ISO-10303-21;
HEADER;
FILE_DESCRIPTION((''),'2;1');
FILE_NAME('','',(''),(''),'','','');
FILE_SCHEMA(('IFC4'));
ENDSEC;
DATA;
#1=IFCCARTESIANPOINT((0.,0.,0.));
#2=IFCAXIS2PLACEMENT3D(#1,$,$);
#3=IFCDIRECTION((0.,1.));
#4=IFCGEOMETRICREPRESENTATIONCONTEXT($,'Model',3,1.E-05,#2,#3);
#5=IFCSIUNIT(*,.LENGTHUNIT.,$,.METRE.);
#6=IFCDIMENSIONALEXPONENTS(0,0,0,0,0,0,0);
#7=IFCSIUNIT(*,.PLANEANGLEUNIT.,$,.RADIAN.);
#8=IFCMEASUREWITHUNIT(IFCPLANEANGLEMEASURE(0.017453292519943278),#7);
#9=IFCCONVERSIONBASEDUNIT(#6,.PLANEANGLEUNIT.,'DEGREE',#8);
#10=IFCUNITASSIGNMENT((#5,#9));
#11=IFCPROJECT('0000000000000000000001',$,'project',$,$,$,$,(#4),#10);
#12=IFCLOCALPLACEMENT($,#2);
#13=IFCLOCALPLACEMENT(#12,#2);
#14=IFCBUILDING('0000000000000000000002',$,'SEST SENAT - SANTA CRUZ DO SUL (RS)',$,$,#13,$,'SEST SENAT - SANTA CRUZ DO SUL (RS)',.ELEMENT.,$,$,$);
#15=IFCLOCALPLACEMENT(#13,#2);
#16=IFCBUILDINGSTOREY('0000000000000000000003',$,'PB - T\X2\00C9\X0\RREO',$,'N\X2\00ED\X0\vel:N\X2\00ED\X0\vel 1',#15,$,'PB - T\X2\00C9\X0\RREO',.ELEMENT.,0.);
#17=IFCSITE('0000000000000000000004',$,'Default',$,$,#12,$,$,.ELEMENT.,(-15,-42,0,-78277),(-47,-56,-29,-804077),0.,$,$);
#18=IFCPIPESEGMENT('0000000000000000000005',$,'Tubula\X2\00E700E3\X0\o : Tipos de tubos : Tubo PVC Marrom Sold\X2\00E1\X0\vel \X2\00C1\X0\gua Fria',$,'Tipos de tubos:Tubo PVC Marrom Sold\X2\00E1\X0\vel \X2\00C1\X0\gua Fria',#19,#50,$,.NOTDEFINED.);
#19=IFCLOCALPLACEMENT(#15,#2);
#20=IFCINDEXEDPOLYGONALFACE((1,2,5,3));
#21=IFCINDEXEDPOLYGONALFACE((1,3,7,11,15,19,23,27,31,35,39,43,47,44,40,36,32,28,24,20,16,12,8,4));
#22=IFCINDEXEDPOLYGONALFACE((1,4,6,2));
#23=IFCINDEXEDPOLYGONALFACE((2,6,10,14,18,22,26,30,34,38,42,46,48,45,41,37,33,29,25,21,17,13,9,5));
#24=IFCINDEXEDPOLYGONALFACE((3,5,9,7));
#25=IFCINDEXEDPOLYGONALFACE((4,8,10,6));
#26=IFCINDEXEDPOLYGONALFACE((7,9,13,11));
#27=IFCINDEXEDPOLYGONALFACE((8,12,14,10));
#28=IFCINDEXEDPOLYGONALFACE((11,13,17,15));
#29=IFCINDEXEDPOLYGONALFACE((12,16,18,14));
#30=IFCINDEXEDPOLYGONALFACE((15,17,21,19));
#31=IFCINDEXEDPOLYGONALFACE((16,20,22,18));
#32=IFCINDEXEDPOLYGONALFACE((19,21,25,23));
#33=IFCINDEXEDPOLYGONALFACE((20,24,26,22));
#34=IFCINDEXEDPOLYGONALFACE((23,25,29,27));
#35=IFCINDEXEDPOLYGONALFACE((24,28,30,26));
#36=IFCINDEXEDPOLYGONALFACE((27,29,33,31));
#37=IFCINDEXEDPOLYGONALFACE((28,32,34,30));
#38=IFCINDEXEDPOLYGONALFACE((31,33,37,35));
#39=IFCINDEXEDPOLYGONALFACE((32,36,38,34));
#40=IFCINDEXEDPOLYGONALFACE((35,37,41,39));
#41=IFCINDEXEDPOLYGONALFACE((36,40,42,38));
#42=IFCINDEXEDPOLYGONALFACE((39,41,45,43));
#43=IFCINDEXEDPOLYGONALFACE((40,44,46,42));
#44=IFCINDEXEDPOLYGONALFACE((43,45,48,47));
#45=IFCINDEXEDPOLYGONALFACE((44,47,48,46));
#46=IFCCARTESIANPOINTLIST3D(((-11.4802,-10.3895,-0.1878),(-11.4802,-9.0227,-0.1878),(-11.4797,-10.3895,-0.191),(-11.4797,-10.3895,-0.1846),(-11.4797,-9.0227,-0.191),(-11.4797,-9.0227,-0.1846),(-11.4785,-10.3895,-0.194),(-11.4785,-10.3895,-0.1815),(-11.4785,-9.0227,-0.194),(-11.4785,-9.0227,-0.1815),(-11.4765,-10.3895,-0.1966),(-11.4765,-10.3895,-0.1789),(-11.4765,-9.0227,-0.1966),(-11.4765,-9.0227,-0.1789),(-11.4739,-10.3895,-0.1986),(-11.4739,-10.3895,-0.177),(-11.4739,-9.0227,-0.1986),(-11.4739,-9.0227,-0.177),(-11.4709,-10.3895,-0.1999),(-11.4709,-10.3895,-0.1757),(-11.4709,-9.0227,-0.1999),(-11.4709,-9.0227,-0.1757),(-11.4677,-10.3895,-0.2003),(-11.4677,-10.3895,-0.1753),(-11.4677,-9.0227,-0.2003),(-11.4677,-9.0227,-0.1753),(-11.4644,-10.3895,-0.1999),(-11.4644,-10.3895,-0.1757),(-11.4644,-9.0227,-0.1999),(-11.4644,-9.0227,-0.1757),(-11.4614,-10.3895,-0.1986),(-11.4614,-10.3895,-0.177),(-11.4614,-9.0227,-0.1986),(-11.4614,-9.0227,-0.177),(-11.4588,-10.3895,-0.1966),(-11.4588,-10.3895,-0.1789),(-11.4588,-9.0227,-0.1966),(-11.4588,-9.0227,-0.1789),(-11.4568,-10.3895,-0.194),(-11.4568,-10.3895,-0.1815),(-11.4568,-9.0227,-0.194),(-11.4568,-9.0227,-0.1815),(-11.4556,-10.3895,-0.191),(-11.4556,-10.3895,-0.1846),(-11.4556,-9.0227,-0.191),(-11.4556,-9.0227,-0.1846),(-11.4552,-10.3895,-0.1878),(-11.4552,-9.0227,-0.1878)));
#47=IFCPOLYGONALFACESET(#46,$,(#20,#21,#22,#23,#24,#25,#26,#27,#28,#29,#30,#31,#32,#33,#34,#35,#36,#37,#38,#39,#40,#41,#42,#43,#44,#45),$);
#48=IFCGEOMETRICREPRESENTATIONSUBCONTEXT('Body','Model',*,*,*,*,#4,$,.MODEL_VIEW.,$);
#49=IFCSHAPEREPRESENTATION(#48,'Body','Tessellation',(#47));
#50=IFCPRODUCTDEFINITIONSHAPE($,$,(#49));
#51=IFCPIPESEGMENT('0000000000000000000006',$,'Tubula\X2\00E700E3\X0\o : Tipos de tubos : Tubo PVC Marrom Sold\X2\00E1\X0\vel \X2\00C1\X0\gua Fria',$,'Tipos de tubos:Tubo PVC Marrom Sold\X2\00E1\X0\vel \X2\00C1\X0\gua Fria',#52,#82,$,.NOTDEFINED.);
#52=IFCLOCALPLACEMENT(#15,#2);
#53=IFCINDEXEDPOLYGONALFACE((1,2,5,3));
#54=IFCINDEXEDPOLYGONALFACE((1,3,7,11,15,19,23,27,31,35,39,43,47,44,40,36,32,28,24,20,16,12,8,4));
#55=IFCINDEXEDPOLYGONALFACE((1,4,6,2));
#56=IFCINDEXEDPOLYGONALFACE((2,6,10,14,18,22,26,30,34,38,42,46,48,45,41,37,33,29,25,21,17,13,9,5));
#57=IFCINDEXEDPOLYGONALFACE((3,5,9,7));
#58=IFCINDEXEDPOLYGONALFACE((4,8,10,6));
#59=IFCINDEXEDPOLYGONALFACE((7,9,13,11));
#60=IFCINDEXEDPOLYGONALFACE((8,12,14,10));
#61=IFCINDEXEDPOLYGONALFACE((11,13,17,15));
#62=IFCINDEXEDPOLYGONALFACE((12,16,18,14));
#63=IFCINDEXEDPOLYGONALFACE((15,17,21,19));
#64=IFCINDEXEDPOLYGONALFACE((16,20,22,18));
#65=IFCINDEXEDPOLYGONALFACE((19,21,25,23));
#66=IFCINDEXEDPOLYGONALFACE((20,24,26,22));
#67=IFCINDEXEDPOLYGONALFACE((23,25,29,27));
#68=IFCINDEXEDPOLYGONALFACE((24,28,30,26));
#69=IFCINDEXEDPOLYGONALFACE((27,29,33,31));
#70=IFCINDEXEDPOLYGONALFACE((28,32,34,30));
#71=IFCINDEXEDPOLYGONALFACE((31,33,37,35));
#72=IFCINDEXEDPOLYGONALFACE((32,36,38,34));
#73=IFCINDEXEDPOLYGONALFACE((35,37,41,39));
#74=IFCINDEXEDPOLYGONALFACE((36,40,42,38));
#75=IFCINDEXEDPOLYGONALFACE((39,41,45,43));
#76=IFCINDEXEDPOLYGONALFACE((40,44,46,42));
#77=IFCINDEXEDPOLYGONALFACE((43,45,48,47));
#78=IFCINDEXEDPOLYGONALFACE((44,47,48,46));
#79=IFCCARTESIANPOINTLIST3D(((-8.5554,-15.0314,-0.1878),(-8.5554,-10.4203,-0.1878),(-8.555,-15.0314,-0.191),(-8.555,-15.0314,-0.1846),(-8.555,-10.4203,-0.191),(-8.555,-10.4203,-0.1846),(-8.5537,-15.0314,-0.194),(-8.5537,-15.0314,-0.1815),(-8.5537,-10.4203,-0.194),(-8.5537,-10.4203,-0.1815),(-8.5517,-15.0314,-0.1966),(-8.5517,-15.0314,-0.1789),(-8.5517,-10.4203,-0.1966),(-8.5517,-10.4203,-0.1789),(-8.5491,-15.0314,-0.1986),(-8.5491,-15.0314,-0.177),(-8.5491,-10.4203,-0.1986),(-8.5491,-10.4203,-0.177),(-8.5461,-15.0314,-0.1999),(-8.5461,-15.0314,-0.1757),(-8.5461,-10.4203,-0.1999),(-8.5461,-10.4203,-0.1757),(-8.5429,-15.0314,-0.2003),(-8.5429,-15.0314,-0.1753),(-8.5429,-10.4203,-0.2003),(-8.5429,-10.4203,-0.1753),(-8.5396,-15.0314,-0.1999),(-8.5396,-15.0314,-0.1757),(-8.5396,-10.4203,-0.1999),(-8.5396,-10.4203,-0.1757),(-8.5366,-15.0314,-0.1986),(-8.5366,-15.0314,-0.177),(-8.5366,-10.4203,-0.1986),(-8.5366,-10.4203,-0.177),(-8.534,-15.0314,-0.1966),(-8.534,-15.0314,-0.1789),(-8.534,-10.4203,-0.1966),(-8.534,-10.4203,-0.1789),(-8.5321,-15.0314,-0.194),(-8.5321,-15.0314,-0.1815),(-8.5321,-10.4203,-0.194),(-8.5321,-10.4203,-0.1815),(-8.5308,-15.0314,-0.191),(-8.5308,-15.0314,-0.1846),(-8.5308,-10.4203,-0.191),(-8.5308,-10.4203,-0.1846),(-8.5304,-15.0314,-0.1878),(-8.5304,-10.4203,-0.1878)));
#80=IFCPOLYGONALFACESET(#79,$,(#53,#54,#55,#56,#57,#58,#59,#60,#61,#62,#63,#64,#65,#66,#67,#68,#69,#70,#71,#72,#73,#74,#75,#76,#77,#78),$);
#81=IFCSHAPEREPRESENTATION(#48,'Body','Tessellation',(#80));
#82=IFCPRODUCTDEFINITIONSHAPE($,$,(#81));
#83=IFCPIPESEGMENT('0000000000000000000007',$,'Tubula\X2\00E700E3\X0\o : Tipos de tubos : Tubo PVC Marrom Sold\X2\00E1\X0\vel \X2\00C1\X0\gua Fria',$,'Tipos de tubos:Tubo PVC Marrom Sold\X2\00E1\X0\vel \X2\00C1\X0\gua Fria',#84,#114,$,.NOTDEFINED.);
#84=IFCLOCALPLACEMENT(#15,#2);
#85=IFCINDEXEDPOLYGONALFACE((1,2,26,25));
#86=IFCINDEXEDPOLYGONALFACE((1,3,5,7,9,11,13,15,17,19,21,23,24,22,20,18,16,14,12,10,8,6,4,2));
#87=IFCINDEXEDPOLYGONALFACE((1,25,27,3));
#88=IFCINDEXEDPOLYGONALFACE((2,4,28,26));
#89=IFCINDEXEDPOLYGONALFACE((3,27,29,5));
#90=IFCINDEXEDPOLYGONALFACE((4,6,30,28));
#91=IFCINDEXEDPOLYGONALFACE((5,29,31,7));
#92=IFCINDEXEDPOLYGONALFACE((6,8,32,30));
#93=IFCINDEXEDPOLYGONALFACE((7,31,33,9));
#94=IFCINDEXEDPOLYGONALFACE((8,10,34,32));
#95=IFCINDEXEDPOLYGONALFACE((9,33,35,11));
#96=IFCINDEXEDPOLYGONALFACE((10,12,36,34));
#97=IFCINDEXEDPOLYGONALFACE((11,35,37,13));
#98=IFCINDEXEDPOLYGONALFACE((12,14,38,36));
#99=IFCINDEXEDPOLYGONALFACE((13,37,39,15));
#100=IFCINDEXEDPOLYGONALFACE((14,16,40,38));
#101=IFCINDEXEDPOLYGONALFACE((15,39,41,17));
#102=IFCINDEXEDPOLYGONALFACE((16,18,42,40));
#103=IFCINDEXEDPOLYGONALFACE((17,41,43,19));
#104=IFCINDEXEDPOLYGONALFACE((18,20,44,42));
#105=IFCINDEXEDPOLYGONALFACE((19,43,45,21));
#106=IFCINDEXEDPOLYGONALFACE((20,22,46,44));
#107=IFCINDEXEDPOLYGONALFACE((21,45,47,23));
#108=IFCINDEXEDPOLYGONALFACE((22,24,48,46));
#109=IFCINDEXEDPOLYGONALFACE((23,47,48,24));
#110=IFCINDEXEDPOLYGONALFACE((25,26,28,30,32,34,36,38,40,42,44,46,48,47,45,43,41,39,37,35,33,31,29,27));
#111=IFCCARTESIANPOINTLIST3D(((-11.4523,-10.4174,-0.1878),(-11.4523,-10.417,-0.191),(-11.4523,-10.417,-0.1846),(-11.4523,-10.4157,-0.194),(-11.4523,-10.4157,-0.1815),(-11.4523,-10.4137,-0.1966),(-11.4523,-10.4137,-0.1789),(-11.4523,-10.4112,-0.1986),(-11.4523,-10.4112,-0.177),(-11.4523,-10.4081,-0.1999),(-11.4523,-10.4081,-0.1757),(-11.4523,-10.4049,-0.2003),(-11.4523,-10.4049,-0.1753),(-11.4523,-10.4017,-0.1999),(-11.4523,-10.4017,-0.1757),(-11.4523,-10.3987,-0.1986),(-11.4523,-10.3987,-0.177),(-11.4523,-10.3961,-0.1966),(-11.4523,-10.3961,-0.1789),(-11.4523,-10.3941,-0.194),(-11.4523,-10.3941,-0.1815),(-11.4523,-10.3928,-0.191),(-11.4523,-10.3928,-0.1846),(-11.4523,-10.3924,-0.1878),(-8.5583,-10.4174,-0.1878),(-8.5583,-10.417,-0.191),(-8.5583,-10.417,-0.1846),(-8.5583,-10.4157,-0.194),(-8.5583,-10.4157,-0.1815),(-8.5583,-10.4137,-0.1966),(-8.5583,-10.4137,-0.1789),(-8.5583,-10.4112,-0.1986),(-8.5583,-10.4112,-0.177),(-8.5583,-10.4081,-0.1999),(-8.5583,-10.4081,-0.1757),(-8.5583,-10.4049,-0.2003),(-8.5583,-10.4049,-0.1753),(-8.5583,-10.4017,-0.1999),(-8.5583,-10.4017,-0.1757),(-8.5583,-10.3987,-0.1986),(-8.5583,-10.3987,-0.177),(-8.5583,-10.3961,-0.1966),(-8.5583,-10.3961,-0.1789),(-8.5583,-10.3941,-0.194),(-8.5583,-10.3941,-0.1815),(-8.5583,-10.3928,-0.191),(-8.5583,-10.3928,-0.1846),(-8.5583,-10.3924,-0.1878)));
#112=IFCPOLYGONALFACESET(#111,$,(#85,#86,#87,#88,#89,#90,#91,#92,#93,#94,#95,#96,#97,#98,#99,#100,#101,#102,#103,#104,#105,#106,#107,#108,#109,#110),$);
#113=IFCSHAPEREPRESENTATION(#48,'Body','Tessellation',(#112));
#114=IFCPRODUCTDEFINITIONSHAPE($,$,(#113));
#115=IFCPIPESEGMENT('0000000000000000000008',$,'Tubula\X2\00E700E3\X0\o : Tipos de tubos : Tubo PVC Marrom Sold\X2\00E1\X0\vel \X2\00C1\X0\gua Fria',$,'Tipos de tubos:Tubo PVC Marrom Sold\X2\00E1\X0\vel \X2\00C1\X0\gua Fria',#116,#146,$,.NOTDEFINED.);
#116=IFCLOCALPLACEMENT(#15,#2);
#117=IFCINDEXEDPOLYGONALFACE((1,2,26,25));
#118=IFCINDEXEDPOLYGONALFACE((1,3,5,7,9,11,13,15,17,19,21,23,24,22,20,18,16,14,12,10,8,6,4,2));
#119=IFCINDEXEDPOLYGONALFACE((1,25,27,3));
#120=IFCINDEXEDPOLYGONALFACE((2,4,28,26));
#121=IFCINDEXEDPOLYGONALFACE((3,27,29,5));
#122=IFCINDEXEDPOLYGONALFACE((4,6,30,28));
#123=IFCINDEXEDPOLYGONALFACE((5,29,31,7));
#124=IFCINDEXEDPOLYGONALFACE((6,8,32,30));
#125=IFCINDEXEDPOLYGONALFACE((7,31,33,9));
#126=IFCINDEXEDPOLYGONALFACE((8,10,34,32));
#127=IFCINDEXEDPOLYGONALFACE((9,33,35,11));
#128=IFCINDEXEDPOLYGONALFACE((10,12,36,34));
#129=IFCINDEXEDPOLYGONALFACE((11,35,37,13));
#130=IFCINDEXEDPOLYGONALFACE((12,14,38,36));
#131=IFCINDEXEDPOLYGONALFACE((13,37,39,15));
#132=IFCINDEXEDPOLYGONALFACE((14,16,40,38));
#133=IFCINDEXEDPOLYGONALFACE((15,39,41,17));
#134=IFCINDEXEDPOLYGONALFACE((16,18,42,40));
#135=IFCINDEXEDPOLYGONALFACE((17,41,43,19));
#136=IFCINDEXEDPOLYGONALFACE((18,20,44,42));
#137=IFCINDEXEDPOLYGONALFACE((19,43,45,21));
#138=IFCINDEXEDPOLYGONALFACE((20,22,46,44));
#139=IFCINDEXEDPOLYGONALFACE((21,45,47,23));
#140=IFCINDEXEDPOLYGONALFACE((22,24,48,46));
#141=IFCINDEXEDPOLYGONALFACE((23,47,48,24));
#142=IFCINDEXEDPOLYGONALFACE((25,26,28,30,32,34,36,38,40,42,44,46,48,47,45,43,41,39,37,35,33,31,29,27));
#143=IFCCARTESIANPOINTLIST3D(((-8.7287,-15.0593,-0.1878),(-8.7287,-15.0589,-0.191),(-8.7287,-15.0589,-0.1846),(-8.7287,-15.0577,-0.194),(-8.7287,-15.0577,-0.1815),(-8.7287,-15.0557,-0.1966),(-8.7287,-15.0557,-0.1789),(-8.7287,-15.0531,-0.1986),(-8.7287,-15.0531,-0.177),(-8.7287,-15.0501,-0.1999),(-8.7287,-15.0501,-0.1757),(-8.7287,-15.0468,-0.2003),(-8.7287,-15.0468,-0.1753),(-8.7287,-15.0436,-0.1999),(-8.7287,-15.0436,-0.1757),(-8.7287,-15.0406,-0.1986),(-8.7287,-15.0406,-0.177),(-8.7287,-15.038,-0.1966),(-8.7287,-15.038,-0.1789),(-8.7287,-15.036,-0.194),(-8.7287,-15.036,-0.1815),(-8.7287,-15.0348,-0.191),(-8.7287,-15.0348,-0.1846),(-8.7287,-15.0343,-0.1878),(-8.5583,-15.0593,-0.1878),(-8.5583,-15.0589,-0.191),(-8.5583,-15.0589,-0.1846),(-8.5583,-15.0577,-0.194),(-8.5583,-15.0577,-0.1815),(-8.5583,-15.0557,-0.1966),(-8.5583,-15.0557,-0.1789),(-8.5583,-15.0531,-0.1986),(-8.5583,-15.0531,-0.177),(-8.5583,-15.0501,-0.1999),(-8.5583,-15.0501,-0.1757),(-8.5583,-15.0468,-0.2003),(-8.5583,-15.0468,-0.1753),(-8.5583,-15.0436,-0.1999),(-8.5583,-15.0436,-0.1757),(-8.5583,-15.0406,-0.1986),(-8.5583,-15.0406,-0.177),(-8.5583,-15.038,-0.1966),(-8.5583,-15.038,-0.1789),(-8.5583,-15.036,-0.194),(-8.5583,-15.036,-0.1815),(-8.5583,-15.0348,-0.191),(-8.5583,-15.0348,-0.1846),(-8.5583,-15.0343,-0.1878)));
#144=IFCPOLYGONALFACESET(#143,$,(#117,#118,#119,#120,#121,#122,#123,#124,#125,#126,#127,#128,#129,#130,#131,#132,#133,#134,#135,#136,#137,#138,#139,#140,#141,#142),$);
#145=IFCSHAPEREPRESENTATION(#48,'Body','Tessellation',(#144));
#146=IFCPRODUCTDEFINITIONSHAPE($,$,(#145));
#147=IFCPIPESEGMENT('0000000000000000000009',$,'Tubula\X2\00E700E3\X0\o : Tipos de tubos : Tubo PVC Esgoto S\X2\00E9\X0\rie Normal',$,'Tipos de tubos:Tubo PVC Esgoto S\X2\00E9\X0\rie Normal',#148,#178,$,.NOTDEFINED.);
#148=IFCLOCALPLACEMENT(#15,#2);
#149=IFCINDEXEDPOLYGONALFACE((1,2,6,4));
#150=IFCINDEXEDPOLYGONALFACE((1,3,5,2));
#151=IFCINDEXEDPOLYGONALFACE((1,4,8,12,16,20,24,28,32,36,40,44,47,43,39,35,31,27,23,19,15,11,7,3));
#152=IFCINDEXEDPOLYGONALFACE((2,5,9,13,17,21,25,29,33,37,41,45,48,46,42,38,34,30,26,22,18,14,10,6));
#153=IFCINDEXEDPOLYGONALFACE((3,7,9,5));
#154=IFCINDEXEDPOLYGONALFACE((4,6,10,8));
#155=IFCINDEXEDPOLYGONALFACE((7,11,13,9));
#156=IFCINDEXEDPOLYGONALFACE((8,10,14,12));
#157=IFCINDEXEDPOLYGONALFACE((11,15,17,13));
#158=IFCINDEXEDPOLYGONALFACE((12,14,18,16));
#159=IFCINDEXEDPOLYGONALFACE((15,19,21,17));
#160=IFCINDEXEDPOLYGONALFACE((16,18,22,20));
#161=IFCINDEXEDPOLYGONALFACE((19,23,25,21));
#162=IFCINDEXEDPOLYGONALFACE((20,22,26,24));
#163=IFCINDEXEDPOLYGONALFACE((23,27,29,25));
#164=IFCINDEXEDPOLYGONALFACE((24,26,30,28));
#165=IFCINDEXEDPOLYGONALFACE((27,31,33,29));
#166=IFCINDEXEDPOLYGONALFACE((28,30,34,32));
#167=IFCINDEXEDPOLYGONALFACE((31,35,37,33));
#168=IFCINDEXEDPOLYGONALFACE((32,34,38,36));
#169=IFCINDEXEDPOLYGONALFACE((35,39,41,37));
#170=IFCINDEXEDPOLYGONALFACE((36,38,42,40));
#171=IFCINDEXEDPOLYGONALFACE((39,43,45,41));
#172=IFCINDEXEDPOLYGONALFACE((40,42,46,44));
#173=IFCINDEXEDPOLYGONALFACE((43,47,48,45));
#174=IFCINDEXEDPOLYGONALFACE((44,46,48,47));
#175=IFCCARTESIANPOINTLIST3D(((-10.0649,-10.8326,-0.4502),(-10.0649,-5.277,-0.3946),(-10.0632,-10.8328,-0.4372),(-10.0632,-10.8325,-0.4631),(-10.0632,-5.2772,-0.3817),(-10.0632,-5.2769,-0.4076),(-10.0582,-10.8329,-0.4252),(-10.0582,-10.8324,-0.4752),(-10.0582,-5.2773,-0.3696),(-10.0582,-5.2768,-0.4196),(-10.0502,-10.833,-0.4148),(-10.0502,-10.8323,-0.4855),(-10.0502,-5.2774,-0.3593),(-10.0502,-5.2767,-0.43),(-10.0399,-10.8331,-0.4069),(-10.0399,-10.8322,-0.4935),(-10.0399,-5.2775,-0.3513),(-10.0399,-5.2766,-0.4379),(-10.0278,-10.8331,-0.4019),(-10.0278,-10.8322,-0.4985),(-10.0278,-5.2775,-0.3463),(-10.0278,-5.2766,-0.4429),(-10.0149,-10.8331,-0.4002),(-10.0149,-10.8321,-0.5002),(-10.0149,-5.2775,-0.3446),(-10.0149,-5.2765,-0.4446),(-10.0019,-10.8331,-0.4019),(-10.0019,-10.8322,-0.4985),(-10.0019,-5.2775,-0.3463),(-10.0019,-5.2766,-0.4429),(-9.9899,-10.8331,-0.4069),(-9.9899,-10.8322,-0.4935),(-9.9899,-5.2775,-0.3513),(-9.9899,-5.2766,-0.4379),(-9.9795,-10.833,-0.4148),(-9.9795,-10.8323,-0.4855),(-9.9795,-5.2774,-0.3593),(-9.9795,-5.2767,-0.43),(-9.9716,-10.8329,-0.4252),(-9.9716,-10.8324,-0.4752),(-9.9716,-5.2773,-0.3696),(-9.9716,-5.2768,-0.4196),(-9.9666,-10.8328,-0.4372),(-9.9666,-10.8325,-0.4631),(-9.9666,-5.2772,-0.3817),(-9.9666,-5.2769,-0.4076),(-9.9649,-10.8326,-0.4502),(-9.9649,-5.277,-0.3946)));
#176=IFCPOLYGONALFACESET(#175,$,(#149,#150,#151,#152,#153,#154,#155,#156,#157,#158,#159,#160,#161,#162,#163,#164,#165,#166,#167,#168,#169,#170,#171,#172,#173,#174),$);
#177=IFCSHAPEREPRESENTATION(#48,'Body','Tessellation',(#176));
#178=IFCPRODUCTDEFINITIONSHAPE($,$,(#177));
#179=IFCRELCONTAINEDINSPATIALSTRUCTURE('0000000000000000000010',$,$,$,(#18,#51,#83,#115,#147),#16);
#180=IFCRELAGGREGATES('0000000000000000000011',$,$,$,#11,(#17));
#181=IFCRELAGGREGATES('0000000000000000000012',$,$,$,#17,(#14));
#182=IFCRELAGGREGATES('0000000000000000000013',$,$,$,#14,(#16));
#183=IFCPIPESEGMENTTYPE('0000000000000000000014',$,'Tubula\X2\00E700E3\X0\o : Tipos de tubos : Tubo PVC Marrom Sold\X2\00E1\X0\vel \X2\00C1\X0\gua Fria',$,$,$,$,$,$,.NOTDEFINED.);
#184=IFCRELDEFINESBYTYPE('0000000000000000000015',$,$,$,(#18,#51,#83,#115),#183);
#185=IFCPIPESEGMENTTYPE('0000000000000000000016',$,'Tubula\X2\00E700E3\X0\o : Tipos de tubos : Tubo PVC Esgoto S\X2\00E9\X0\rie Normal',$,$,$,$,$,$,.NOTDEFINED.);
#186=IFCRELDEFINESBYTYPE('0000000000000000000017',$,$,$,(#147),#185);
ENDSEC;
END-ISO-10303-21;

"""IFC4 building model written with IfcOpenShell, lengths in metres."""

from ifc_helpers import new_model, entity, si_unit, converted_unit, direction, frame, origin, place, context, subcontext, project, spatial, arc, indexed_curve, outline, extrude, type_object, element, save


model = new_model("IFC4")

# Units and contexts
model_context = context("Model", 3, precision=1e-05, world=origin(), true_north=direction((0.0, 1.0)))
body_context = subcontext(model_context, "Body", "Model", "MODEL_VIEW")
ifc_project = project(units=[si_unit("LENGTHUNIT", "METRE"), converted_unit("PLANEANGLEUNIT", "DEGREE", entity("IfcPlaneAngleMeasure", 0.017453292519943278), si_unit("PLANEANGLEUNIT", "RADIAN"), dimensions=[0, 0, 0, 0, 0, 0, 0])], contexts=[model_context])

# Site, building, storey
site_placement = place(None, origin())
site = spatial("IfcSite", under=ifc_project, at=site_placement, Name="Default", CompositionType="ELEMENT", RefLatitude=(-15, -42, 0, -78277), RefLongitude=(-47, -56, -29, -804077), RefElevation=0.0)
building_placement = place(site_placement, origin())
building = spatial("IfcBuilding", under=site, at=building_placement, Name="SEST SENAT - SANTA CRUZ DO SUL (RS)", LongName="SEST SENAT - SANTA CRUZ DO SUL (RS)", CompositionType="ELEMENT")
storey_placement = place(building_placement, origin())
storey = spatial("IfcBuildingStorey", under=building, at=storey_placement, Name="PB - TÉRREO", ObjectType="Nível:Nível 1", LongName="PB - TÉRREO", CompositionType="ELEMENT", Elevation=0.0)

# Pipe segments
pipe_segment_type_1 = type_object("IfcPipeSegmentType", Name="Tubulação : Tipos de tubos : Tubo PVC Marrom Soldável Água Fria", PredefinedType="NOTDEFINED")
pipe_segment_1_placement = place(storey_placement, frame((-11.4818, -10.3895, -0.2019)))
element("IfcPipeSegment", 1, at=pipe_segment_1_placement, inside=storey, type_object=pipe_segment_type_1, Name="Tubulação : Tipos de tubos : Tubo PVC Marrom Soldável Água Fria", ObjectType="Tipos de tubos:Tubo PVC Marrom Soldável Água Fria", PredefinedType="NOTDEFINED", context=body_context, shape_type="SweptSolid", body=[
    extrude(outline(indexed_curve([(0.0125, 0.0), (0.0088, 0.0088), (0.0, 0.0125), (-0.0088, 0.0088), (-0.0125, 0.0), (-0.0088, -0.0088), (0.0, -0.0125), (0.0088, -0.0088)], segments=[arc(1, 2, 3), arc(3, 4, 5), arc(5, 6, 7), arc(7, 8, 1)], self_intersect=False)), frame((0.0141, 0.0, 0.0141), z_axis=(0.0, 1.0, 0.0), x_axis=(-1.0, 0.0, 0.0)), (0.0, 0.0, 1.0), 1.3668),
])
pipe_segment_2_placement = place(storey_placement, frame((-8.557, -15.0314, -0.2019)))
element("IfcPipeSegment", 2, at=pipe_segment_2_placement, inside=storey, type_object=pipe_segment_type_1, Name="Tubulação : Tipos de tubos : Tubo PVC Marrom Soldável Água Fria", ObjectType="Tipos de tubos:Tubo PVC Marrom Soldável Água Fria", PredefinedType="NOTDEFINED", context=body_context, shape_type="SweptSolid", body=[
    extrude(outline(indexed_curve([(0.0125, 0.0), (0.0088, 0.0088), (0.0, 0.0125), (-0.0088, 0.0088), (-0.0125, 0.0), (-0.0088, -0.0088), (0.0, -0.0125), (0.0088, -0.0088)], segments=[arc(1, 2, 3), arc(3, 4, 5), arc(5, 6, 7), arc(7, 8, 1)], self_intersect=False)), frame((0.0141, 0.0, 0.0141), z_axis=(0.0, 1.0, 0.0), x_axis=(-1.0, 0.0, 0.0)), (0.0, 0.0, 1.0), 4.6111),
])
pipe_segment_3_placement = place(storey_placement, frame((-11.4523, -10.419, -0.2019)))
element("IfcPipeSegment", 3, at=pipe_segment_3_placement, inside=storey, type_object=pipe_segment_type_1, Name="Tubulação : Tipos de tubos : Tubo PVC Marrom Soldável Água Fria", ObjectType="Tipos de tubos:Tubo PVC Marrom Soldável Água Fria", PredefinedType="NOTDEFINED", context=body_context, shape_type="SweptSolid", body=[
    extrude(outline(indexed_curve([(0.0125, 0.0), (0.0088, 0.0088), (0.0, 0.0125), (-0.0088, 0.0088), (-0.0125, 0.0), (-0.0088, -0.0088), (0.0, -0.0125), (0.0088, -0.0088)], segments=[arc(1, 2, 3), arc(3, 4, 5), arc(5, 6, 7), arc(7, 8, 1)], self_intersect=False)), frame((0.0, 0.0141, 0.0141), z_axis=(1.0, 0.0, 0.0), x_axis=(0.0, -1.0, 0.0)), (0.0, 0.0, 1.0), 2.894),
])
pipe_segment_4_placement = place(storey_placement, frame((-8.7287, -15.0609, -0.2019)))
element("IfcPipeSegment", 4, at=pipe_segment_4_placement, inside=storey, type_object=pipe_segment_type_1, Name="Tubulação : Tipos de tubos : Tubo PVC Marrom Soldável Água Fria", ObjectType="Tipos de tubos:Tubo PVC Marrom Soldável Água Fria", PredefinedType="NOTDEFINED", context=body_context, shape_type="SweptSolid", body=[
    extrude(outline(indexed_curve([(0.0125, 0.0), (0.0088, 0.0088), (0.0, 0.0125), (-0.0088, 0.0088), (-0.0125, 0.0), (-0.0088, -0.0088), (0.0, -0.0125), (0.0088, -0.0088)], segments=[arc(1, 2, 3), arc(3, 4, 5), arc(5, 6, 7), arc(7, 8, 1)], self_intersect=False)), frame((0.0, 0.0141, 0.0141), z_axis=(1.0, 0.0, 0.0), x_axis=(0.0, 1.0, 0.0)), (0.0, 0.0, 1.0), 0.1704),
])
pipe_segment_type_2 = type_object("IfcPipeSegmentType", Name="Tubulação : Tipos de tubos : Tubo PVC Esgoto Série Normal", PredefinedType="NOTDEFINED")
pipe_segment_5_placement = place(storey_placement, frame((-10.0665, -10.8347, -0.5018)))
element("IfcPipeSegment", 5, at=pipe_segment_5_placement, inside=storey, type_object=pipe_segment_type_2, Name="Tubulação : Tipos de tubos : Tubo PVC Esgoto Série Normal", ObjectType="Tipos de tubos:Tubo PVC Esgoto Série Normal", PredefinedType="NOTDEFINED", context=body_context, shape_type="SweptSolid", body=[
    extrude(outline(indexed_curve([(0.05, 0.0), (0.0354, 0.0354), (0.0, 0.05), (-0.0354, 0.0354), (-0.05, 0.0), (-0.0354, -0.0354), (0.0, -0.05), (0.0354, -0.0354)], segments=[arc(1, 2, 3), arc(3, 4, 5), arc(5, 6, 7), arc(7, 8, 1)], self_intersect=False)), frame((0.0516, 0.0021, 0.0516), z_axis=(0.0, 0.99995, 0.01), x_axis=(-1.0, 0.0, 0.0)), (0.0, 0.0, 1.0), 5.5559),
])

save(model, "model.ifc")
